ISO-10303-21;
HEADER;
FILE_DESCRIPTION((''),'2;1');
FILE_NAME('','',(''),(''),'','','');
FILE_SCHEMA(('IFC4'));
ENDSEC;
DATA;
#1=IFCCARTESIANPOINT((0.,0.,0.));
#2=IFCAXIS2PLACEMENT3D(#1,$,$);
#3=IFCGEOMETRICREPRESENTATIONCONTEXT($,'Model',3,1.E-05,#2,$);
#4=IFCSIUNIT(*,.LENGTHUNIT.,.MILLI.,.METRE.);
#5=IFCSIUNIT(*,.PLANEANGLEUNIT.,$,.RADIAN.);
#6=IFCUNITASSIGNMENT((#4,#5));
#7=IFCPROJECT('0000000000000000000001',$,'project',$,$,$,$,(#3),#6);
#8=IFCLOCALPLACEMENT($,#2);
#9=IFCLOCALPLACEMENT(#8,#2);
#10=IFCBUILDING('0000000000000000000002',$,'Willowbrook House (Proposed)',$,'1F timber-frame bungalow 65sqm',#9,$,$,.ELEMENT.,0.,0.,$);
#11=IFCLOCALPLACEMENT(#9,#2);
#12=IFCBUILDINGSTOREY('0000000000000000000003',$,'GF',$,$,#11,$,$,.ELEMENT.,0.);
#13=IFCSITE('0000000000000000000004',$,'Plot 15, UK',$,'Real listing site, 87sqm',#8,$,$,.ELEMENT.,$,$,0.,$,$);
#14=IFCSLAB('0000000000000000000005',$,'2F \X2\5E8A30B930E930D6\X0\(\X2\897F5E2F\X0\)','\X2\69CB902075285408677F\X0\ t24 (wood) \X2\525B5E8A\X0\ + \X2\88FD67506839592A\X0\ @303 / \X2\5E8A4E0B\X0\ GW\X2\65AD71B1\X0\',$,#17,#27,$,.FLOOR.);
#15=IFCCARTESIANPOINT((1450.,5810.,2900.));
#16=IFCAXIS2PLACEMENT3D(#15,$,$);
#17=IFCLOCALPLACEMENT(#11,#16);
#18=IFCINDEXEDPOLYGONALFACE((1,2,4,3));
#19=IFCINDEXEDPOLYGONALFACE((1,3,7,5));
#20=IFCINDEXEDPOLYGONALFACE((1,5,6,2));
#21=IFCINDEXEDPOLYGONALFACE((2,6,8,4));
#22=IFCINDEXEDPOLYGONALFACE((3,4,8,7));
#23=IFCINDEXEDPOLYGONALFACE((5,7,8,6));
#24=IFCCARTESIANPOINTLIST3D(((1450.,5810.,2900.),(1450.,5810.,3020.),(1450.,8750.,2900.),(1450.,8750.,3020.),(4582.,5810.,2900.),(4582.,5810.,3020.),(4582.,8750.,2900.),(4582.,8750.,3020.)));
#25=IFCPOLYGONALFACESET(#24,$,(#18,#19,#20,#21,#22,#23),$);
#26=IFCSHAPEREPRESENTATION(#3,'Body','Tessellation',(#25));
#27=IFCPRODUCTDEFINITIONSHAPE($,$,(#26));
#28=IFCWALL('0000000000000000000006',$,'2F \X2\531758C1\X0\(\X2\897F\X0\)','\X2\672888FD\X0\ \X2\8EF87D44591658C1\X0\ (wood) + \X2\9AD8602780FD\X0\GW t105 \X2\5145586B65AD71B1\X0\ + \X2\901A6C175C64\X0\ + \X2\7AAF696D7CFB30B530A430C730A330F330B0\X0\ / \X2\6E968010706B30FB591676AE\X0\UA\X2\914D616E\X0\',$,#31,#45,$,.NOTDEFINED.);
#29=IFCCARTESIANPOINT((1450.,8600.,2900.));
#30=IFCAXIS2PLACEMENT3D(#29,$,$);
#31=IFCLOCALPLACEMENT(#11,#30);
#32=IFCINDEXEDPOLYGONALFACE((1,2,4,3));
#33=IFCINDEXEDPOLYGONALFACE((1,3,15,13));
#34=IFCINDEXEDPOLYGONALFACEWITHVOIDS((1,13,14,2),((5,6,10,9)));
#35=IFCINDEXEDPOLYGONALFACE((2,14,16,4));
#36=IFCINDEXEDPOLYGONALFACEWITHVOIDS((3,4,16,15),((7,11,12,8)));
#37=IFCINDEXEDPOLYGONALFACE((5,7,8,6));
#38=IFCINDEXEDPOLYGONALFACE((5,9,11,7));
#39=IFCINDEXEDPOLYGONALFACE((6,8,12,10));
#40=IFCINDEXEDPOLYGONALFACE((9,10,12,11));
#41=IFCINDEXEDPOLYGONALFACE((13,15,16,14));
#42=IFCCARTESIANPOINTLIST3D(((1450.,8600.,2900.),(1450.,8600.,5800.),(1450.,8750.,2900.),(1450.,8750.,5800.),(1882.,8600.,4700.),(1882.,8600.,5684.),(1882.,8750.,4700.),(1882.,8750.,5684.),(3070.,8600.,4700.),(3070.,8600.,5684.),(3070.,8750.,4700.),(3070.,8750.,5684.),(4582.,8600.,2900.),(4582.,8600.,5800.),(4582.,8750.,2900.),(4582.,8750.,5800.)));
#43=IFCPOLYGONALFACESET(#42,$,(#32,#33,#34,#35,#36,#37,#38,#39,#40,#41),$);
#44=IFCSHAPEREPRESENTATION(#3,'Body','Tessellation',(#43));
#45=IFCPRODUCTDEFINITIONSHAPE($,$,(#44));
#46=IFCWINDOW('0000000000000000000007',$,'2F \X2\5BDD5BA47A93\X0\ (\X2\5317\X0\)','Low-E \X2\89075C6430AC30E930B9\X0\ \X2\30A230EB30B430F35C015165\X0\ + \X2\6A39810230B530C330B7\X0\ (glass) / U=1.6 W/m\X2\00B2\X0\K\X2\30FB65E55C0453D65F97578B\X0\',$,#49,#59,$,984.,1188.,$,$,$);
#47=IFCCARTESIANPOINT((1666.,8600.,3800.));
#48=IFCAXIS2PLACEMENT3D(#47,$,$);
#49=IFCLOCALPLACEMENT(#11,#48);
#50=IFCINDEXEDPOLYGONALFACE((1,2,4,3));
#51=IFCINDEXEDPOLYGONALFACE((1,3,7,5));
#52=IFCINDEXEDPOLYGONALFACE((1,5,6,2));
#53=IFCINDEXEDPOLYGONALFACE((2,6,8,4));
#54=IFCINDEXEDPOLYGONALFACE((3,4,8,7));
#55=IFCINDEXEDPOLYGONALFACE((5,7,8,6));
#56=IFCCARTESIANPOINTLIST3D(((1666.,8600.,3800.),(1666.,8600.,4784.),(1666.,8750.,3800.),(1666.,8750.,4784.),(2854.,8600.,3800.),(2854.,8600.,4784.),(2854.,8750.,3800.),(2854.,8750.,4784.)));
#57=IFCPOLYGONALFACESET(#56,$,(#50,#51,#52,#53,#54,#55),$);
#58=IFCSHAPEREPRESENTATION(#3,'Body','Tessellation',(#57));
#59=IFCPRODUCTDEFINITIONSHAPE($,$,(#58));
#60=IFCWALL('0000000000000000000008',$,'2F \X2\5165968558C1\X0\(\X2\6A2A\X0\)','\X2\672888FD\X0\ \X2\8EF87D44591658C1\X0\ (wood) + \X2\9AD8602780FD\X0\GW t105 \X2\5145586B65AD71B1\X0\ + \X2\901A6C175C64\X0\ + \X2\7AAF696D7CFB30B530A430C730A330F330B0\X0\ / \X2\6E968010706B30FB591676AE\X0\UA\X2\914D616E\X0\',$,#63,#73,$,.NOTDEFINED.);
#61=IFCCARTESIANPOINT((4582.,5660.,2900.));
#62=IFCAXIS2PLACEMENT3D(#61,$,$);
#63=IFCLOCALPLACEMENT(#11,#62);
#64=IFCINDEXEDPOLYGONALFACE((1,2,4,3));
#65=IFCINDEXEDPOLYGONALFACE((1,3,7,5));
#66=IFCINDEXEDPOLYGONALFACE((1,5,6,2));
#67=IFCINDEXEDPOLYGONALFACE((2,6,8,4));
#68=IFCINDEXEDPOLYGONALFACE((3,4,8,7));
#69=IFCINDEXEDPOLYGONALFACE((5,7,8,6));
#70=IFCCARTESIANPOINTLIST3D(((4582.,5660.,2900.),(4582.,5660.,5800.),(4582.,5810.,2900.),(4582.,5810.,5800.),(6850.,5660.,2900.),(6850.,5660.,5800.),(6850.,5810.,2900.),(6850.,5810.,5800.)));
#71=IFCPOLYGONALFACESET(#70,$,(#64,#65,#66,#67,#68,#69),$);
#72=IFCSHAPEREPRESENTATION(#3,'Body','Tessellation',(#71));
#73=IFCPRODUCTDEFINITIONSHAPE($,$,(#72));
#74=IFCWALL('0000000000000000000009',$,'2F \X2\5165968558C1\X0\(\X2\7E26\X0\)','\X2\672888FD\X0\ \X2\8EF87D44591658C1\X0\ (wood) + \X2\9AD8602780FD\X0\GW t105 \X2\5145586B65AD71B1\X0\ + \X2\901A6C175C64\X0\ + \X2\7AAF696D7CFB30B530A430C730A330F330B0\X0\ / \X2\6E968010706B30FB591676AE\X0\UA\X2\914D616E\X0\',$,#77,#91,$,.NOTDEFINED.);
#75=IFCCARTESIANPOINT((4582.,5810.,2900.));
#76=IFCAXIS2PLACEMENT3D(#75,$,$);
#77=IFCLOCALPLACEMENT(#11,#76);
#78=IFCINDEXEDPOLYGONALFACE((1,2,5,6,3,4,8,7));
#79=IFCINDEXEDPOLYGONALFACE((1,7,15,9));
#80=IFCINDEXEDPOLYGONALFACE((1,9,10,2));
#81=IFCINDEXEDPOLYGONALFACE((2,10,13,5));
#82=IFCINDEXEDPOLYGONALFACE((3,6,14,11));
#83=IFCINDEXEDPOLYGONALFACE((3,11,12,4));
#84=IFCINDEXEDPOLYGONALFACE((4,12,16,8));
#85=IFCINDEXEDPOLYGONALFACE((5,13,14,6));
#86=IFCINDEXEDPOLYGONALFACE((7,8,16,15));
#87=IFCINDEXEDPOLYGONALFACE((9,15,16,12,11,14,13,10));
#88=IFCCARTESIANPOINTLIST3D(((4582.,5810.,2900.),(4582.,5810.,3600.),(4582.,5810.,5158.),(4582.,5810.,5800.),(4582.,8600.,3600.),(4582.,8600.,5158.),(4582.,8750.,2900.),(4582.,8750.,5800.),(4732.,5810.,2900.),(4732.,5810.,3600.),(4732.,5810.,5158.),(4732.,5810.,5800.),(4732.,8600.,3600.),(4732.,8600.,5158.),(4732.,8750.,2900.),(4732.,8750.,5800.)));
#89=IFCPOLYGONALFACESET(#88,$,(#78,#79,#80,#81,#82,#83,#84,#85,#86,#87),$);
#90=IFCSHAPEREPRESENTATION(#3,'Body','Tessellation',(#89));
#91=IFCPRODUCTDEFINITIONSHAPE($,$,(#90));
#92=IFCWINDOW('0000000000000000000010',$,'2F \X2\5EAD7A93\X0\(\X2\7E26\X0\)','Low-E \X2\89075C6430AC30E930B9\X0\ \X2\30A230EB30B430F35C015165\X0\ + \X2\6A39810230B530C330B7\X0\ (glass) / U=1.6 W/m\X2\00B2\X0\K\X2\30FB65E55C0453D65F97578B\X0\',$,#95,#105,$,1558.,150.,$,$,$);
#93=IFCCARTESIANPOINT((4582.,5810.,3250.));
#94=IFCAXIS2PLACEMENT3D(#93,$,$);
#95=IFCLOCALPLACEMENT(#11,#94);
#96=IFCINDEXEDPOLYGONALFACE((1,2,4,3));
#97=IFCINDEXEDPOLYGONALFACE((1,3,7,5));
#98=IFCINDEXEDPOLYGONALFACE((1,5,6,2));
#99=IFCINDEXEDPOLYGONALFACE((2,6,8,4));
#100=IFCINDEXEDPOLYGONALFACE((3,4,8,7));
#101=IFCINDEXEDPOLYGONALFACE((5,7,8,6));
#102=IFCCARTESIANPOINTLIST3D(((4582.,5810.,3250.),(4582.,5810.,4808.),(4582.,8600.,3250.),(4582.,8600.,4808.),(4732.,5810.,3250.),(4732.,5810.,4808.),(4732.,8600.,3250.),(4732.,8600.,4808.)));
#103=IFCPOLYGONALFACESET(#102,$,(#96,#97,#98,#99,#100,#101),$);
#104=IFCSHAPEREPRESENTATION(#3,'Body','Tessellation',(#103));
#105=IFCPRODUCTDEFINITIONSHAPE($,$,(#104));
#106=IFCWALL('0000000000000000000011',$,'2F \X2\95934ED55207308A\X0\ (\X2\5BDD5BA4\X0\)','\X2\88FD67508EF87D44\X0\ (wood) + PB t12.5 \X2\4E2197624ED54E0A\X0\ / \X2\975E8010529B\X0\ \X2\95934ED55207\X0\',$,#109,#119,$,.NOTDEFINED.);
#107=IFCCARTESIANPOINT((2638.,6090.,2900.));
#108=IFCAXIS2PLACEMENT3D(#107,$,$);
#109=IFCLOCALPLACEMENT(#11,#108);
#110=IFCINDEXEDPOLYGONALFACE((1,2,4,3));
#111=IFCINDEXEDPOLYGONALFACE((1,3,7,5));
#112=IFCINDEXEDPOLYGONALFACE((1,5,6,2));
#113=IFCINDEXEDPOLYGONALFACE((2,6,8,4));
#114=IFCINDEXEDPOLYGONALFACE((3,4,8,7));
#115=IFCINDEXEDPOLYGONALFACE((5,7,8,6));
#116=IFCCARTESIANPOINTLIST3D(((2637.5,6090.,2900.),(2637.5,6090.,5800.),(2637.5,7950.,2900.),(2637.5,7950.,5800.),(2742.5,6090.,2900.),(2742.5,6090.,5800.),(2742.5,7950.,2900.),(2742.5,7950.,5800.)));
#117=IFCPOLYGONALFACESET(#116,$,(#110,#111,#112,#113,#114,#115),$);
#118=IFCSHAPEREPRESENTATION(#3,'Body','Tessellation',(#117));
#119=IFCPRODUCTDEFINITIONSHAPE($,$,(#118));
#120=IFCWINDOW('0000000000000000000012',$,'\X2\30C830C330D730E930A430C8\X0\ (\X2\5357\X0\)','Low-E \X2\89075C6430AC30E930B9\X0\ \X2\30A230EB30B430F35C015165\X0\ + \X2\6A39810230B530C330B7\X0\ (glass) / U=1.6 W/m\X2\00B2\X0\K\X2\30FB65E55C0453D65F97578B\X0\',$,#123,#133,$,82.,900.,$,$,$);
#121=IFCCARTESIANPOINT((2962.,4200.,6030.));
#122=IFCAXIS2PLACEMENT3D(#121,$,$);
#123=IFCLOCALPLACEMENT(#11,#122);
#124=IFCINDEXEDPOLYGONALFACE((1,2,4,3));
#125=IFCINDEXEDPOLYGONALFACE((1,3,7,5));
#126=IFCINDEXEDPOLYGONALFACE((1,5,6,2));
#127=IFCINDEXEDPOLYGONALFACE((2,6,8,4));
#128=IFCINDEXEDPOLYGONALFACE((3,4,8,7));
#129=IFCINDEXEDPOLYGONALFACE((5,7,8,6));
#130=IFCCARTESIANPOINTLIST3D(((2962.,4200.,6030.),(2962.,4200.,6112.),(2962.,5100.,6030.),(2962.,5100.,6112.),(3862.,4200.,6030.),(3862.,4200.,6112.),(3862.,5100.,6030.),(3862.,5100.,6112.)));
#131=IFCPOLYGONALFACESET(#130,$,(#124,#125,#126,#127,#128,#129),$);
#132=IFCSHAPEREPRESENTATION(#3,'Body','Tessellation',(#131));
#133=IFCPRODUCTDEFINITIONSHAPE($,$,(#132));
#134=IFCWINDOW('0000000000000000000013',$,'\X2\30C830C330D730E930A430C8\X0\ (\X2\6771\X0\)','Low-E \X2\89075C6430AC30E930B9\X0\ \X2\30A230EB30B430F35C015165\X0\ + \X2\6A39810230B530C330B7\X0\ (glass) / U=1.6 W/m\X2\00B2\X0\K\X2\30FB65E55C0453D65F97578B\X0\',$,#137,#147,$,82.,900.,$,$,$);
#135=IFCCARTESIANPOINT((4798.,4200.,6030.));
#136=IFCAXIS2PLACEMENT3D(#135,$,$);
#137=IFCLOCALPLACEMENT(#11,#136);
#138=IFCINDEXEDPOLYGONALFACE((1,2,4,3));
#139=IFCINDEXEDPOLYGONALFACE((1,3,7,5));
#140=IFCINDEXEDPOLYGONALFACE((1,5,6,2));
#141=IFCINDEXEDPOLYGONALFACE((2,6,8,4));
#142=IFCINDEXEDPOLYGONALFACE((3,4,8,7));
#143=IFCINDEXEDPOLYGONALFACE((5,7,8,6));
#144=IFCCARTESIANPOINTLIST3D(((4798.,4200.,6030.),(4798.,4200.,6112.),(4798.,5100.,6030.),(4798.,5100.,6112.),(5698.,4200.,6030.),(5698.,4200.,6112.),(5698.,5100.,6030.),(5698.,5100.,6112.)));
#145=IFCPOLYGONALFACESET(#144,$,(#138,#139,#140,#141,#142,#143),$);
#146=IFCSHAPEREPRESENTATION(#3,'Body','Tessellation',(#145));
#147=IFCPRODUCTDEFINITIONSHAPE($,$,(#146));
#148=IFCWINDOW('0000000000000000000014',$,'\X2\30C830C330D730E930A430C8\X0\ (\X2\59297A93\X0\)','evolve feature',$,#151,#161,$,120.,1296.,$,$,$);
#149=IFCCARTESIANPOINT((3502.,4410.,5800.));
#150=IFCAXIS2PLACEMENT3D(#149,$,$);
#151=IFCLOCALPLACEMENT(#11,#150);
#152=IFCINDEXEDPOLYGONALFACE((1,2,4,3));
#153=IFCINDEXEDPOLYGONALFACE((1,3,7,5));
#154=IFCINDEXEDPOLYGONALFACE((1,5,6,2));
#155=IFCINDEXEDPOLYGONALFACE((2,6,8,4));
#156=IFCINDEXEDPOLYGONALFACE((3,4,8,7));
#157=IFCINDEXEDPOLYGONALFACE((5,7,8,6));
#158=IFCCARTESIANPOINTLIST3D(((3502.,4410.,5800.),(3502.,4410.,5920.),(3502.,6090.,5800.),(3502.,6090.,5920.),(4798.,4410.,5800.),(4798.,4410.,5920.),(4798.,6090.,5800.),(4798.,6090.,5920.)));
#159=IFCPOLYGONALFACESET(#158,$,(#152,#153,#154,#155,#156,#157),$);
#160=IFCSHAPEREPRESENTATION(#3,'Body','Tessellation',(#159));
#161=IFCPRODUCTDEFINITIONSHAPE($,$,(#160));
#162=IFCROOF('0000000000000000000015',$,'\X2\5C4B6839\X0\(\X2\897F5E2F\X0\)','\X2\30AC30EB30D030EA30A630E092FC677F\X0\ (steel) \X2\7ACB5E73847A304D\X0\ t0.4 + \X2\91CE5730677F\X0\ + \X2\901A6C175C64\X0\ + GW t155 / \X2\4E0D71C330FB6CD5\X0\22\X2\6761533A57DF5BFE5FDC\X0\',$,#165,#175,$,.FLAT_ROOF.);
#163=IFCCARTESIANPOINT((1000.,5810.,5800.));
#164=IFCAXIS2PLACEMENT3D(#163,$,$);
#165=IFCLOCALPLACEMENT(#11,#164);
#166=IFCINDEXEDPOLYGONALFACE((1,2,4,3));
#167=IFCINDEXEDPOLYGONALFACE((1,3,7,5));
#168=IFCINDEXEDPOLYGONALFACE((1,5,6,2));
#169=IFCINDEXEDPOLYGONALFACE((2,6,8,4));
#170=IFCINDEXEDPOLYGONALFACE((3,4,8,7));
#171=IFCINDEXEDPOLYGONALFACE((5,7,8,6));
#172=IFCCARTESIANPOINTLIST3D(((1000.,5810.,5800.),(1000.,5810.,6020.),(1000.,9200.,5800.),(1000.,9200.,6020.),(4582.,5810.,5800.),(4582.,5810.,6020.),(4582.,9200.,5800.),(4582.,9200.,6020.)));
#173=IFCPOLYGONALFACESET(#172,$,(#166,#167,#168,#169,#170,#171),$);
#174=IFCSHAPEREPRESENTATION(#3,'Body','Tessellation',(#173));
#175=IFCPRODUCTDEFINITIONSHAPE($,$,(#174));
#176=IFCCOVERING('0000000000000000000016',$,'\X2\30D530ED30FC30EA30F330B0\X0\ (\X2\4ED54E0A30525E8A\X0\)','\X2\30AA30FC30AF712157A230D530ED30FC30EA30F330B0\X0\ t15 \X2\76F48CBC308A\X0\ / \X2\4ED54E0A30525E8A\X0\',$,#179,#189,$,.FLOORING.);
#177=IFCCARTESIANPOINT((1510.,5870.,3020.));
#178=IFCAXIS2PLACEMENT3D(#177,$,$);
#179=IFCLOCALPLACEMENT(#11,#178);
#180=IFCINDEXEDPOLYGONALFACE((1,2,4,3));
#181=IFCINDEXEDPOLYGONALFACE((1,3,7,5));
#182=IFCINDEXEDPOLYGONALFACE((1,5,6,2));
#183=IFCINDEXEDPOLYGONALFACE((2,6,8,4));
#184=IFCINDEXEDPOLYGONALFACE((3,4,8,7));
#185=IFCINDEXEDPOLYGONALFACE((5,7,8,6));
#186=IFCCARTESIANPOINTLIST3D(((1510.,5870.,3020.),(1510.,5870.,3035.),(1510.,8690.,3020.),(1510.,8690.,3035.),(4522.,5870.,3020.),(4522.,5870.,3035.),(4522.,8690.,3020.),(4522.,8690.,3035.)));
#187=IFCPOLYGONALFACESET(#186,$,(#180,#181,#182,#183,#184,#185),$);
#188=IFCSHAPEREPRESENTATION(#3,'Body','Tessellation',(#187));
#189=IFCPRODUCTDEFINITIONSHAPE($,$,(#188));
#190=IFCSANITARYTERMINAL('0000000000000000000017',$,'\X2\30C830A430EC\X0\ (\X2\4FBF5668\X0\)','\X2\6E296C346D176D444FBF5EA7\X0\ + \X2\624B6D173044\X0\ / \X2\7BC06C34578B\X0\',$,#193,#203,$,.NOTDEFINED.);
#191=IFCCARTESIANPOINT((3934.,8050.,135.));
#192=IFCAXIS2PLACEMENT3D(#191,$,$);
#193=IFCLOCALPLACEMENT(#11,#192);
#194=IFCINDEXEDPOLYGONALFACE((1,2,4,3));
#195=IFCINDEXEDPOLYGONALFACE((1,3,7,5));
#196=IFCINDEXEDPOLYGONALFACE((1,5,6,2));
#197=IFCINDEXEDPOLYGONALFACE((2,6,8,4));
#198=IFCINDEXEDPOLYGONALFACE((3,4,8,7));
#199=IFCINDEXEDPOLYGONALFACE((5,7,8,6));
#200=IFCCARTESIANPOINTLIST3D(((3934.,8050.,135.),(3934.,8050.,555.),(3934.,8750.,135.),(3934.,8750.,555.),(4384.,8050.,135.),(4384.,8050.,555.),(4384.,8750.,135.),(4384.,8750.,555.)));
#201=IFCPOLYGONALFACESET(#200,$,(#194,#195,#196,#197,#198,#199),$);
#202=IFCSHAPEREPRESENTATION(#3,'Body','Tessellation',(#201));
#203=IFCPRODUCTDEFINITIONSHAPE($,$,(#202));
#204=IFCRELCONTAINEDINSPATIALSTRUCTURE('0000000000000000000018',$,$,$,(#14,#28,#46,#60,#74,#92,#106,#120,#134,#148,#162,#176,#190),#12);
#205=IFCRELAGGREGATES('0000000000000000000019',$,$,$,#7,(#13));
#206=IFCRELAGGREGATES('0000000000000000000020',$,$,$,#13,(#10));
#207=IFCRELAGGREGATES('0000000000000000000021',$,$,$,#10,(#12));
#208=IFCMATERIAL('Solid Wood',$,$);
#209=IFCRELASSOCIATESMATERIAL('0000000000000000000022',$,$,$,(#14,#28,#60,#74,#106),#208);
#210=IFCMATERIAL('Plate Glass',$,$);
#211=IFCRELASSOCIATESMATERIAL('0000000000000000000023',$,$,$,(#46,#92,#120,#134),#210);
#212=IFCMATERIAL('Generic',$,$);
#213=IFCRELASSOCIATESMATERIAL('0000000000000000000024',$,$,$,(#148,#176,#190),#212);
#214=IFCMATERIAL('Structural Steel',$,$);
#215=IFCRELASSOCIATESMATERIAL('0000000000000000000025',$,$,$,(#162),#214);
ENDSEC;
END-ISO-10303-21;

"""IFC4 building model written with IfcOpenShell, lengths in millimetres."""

from ifc_helpers import new_model, si_unit, frame, frame_2d, origin, place, context, project, spatial, rectangle, extrude, material, element, fill, save


model = new_model("IFC4")

# Units and contexts
model_context = context("Model", 3, precision=1e-05, world=origin())
ifc_project = project(units=[si_unit("LENGTHUNIT", "METRE", prefix="MILLI"), si_unit("PLANEANGLEUNIT", "RADIAN")], contexts=[model_context])

# Site, building, storey
site_placement = place(None, origin())
site = spatial("IfcSite", under=ifc_project, at=site_placement, Name="Plot 15, UK", ObjectType="Real listing site, 87sqm", CompositionType="ELEMENT", RefElevation=0.0)
building_placement = place(site_placement, origin())
building = spatial("IfcBuilding", under=site, at=building_placement, Name="Willowbrook House (Proposed)", ObjectType="1F timber-frame bungalow 65sqm", CompositionType="ELEMENT", ElevationOfRefHeight=0.0, ElevationOfTerrain=0.0)
storey_placement = place(building_placement, origin())
storey = spatial("IfcBuildingStorey", under=building, at=storey_placement, Name="GF", CompositionType="ELEMENT", Elevation=0.0)

# Slab
ifc_material_1 = material(Name="Solid Wood")
slab_placement = place(storey_placement, frame((1450.0, 5810.0, 2900.0)))
element("IfcSlab", 1, at=slab_placement, inside=storey, material=ifc_material_1, Name="2F 床スラブ(西帯)", Description="構造用合板 t24 (wood) 剛床 + 製材根太 @303 / 床下 GW断熱", PredefinedType="FLOOR", context=model_context, shape_type="SweptSolid", body=[
    extrude(rectangle(XDim=3132.0, YDim=2940.0, at=frame_2d((1566.0, 1470.0))), frame((1450.0, 5810.0, 2900.0)), (0.0, 0.0, 1.0), 120.0),
])

# Wall, opening, window
wall_1_placement = place(storey_placement, frame((1450.0, 8600.0, 2900.0)))
wall_1 = element("IfcWall", 2, at=wall_1_placement, inside=storey, material=ifc_material_1, Name="2F 北壁(西)", Description="木製 軸組外壁 (wood) + 高性能GW t105 充填断熱 + 通気層 + 窯業系サイディング / 準耐火・外皮UA配慮", PredefinedType="NOTDEFINED", context=model_context, shape_type="SweptSolid", body=[
    extrude(rectangle(XDim=3132.0, YDim=150.0, at=frame_2d((1566.0, 75.0))), frame((1450.0, 8600.0, 2900.0)), (0.0, 0.0, 1.0), 2900.0),
])
opening_1_placement = place(storey_placement, frame((1666.0, 8600.0, 3800.0)))
opening_1 = element("IfcOpeningElement", 3, at=opening_1_placement, cuts=wall_1, PredefinedType="NOTDEFINED", context=model_context, shape_type="SweptSolid", body=[
    extrude(rectangle(XDim=1188.0, YDim=150.0, at=frame_2d((594.0, 75.0))), frame((1666.0, 8600.0, 3800.0)), (0.0, 0.0, 1.0), 984.0),
])
ifc_material_2 = material(Name="Plate Glass")
window_1_placement = place(storey_placement, frame((1666.0, 8600.0, 3800.0)))
window_1 = element("IfcWindow", 4, at=window_1_placement, inside=storey, material=ifc_material_2, Name="2F 寝室窓 (北)", Description="Low-E 複層ガラス アルゴン封入 + 樹脂サッシ (glass) / U=1.6 W/m²K・日射取得型", OverallHeight=984.0, OverallWidth=1188.0, context=model_context, shape_type="SweptSolid", body=[
    extrude(rectangle(XDim=1188.0, YDim=150.0, at=frame_2d((594.0, 75.0))), frame((1666.0, 8600.0, 3800.0)), (0.0, 0.0, 1.0), 984.0),
])
fill(opening_1, window_1)

# Wall
wall_2_placement = place(storey_placement, frame((4582.0, 5660.0, 2900.0)))
element("IfcWall", 5, at=wall_2_placement, inside=storey, material=ifc_material_1, Name="2F 入隅壁(横)", Description="木製 軸組外壁 (wood) + 高性能GW t105 充填断熱 + 通気層 + 窯業系サイディング / 準耐火・外皮UA配慮", PredefinedType="NOTDEFINED", context=model_context, shape_type="SweptSolid", body=[
    extrude(rectangle(XDim=2268.0, YDim=150.0, at=frame_2d((1134.0, 75.0))), frame((4582.0, 5660.0, 2900.0)), (0.0, 0.0, 1.0), 2900.0),
])

# Wall, opening, window
wall_3_placement = place(storey_placement, frame((4582.0, 5810.0, 2900.0)))
wall_3 = element("IfcWall", 6, at=wall_3_placement, inside=storey, material=ifc_material_1, Name="2F 入隅壁(縦)", Description="木製 軸組外壁 (wood) + 高性能GW t105 充填断熱 + 通気層 + 窯業系サイディング / 準耐火・外皮UA配慮", PredefinedType="NOTDEFINED", context=model_context, shape_type="SweptSolid", body=[
    extrude(rectangle(XDim=150.0, YDim=2940.0, at=frame_2d((75.0, 1470.0))), frame((4582.0, 5810.0, 2900.0)), (0.0, 0.0, 1.0), 2900.0),
])
opening_2_placement = place(storey_placement, frame((4582.0, 5810.0, 3250.0)))
opening_2 = element("IfcOpeningElement", 7, at=opening_2_placement, cuts=wall_3, PredefinedType="NOTDEFINED", context=model_context, shape_type="SweptSolid", body=[
    extrude(rectangle(XDim=150.0, YDim=2790.0, at=frame_2d((75.0, 1395.0))), frame((4582.0, 5810.0, 3250.0)), (0.0, 0.0, 1.0), 1558.0),
])
window_2_placement = place(storey_placement, frame((4582.0, 5810.0, 3250.0)))
window_2 = element("IfcWindow", 8, at=window_2_placement, inside=storey, material=ifc_material_2, Name="2F 庭窓(縦)", Description="Low-E 複層ガラス アルゴン封入 + 樹脂サッシ (glass) / U=1.6 W/m²K・日射取得型", OverallHeight=1558.0, OverallWidth=150.0, context=model_context, shape_type="SweptSolid", body=[
    extrude(rectangle(XDim=150.0, YDim=2790.0, at=frame_2d((75.0, 1395.0))), frame((4582.0, 5810.0, 3250.0)), (0.0, 0.0, 1.0), 1558.0),
])
fill(opening_2, window_2)

# Wall
wall_4_placement = place(storey_placement, frame((2638.0, 6090.0, 2900.0)))
element("IfcWall", 9, at=wall_4_placement, inside=storey, material=ifc_material_1, Name="2F 間仕切り (寝室)", Description="製材軸組 (wood) + PB t12.5 両面仕上 / 非耐力 間仕切", PredefinedType="NOTDEFINED", context=model_context, shape_type="SweptSolid", body=[
    extrude(rectangle(XDim=105.0, YDim=1860.0, at=frame_2d((52.0, 930.0))), frame((2638.0, 6090.0, 2900.0)), (0.0, 0.0, 1.0), 2900.0),
])

# Windows
window_3_placement = place(storey_placement, frame((2962.0, 4200.0, 6030.0)))
element("IfcWindow", 10, at=window_3_placement, inside=storey, material=ifc_material_2, Name="トップライト (南)", Description="Low-E 複層ガラス アルゴン封入 + 樹脂サッシ (glass) / U=1.6 W/m²K・日射取得型", OverallHeight=82.0, OverallWidth=900.0, context=model_context, shape_type="SweptSolid", body=[
    extrude(rectangle(XDim=900.0, YDim=900.0, at=frame_2d((450.0, 450.0))), frame((2962.0, 4200.0, 6030.0)), (0.0, 0.0, 1.0), 82.0),
])
window_4_placement = place(storey_placement, frame((4798.0, 4200.0, 6030.0)))
element("IfcWindow", 11, at=window_4_placement, inside=storey, material=ifc_material_2, Name="トップライト (東)", Description="Low-E 複層ガラス アルゴン封入 + 樹脂サッシ (glass) / U=1.6 W/m²K・日射取得型", OverallHeight=82.0, OverallWidth=900.0, context=model_context, shape_type="SweptSolid", body=[
    extrude(rectangle(XDim=900.0, YDim=900.0, at=frame_2d((450.0, 450.0))), frame((4798.0, 4200.0, 6030.0)), (0.0, 0.0, 1.0), 82.0),
])
ifc_material_3 = material(Name="Generic")
window_5_placement = place(storey_placement, frame((3502.0, 4410.0, 5800.0)))
element("IfcWindow", 12, at=window_5_placement, inside=storey, material=ifc_material_3, Name="トップライト (天窓)", Description="evolve feature", OverallHeight=120.0, OverallWidth=1296.0, context=model_context, shape_type="SweptSolid", body=[
    extrude(rectangle(XDim=1296.0, YDim=1680.0, at=frame_2d((648.0, 840.0))), frame((3502.0, 4410.0, 5800.0)), (0.0, 0.0, 1.0), 120.0),
])

# Roof
ifc_material_4 = material(Name="Structural Steel")
for number, where, name in (
    (13, (1000.0, 5810.0, 5800.0), "屋根(西帯)"),
):
    element("IfcRoof", number, at=place(storey_placement, frame(where)), inside=storey, material=ifc_material_4, Name=name, Description="ガルバリウム鋼板 (steel) 立平葺き t0.4 + 野地板 + 通気層 + GW t155 / 不燃・法22条区域対応", PredefinedType="FLAT_ROOF", context=model_context, shape_type="SweptSolid", body=[
        extrude(rectangle(XDim=3582.0, YDim=3390.0, at=frame_2d((1791.0, 1695.0))), frame((1000.0, 5810.0, 5800.0)), (0.0, 0.0, 1.0), 220.0),
    ])

# Covering
covering_placement = place(storey_placement, frame((1510.0, 5870.0, 3020.0)))
element("IfcCovering", 14, at=covering_placement, inside=storey, material=ifc_material_3, Name="フローリング (仕上げ床)", Description="オーク無垢フローリング t15 直貼り / 仕上げ床", PredefinedType="FLOORING", context=model_context, shape_type="SweptSolid", body=[
    extrude(rectangle(XDim=3012.0, YDim=2820.0, at=frame_2d((1506.0, 1410.0))), frame((1510.0, 5870.0, 3020.0)), (0.0, 0.0, 1.0), 15.0),
])

# Sanitary terminal
sanitary_terminal_placement = place(storey_placement, frame((3934.0, 8050.0, 135.0)))
element("IfcSanitaryTerminal", 15, at=sanitary_terminal_placement, inside=storey, material=ifc_material_3, Name="トイレ (便器)", Description="温水洗浄便座 + 手洗い / 節水型", PredefinedType="NOTDEFINED", context=model_context, shape_type="SweptSolid", body=[
    extrude(rectangle(XDim=450.0, YDim=700.0, at=frame_2d((225.0, 350.0))), frame((3934.0, 8050.0, 135.0)), (0.0, 0.0, 1.0), 420.0),
])

save(model, "model.ifc")
